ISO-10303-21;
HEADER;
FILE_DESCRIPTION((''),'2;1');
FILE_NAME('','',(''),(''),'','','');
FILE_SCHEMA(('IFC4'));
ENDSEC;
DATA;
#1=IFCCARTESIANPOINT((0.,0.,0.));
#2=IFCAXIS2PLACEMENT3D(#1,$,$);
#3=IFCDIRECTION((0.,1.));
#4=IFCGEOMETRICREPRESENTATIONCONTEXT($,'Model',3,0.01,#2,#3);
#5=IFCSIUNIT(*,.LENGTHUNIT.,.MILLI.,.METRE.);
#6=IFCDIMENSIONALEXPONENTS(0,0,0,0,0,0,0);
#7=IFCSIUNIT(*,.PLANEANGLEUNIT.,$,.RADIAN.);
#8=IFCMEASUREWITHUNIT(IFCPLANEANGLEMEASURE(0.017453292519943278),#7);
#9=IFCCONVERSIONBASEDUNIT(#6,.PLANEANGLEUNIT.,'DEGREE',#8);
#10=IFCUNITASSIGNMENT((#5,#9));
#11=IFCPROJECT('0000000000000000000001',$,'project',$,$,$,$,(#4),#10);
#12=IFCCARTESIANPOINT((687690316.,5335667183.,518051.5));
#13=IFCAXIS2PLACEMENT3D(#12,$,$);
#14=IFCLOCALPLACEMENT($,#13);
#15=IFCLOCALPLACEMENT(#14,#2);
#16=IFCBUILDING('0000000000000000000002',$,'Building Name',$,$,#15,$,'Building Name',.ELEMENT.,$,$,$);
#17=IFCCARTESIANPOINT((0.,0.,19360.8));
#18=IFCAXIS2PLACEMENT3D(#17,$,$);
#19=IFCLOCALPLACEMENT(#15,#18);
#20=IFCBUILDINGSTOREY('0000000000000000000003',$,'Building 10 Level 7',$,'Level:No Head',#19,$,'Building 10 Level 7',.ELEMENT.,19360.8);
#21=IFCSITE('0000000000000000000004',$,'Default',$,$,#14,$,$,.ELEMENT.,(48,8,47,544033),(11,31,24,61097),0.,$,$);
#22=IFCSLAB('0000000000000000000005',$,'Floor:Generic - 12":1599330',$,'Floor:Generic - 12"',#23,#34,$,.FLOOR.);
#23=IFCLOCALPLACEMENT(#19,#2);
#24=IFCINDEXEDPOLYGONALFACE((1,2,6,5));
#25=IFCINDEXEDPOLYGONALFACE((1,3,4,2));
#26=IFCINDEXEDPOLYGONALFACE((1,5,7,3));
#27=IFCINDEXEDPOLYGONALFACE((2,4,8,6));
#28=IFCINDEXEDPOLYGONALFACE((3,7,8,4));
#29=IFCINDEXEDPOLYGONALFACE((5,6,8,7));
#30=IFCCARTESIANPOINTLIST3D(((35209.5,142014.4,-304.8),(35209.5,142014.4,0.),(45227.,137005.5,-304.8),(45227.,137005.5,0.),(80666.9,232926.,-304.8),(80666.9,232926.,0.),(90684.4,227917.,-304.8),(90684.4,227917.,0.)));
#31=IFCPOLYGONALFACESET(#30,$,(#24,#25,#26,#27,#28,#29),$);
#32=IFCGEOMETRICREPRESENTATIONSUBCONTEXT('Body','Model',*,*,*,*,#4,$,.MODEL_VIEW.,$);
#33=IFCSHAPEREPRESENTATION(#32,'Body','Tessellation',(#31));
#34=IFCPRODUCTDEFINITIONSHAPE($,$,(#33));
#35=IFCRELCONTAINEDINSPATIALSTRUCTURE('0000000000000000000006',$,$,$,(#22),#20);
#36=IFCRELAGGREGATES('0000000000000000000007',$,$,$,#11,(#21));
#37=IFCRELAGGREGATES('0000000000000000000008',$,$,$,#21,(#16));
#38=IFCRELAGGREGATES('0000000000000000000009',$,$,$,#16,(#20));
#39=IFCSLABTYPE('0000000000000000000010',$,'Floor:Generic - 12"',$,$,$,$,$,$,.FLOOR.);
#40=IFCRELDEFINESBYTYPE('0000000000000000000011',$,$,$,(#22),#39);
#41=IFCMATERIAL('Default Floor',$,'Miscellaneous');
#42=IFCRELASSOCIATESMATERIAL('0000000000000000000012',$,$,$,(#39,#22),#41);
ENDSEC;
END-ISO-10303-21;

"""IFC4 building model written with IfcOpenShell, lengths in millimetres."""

from ifc_helpers import new_model, entity, si_unit, converted_unit, direction, frame, origin, place, context, subcontext, project, spatial, indexed_curve, outline, extrude, material, type_object, element, save


model = new_model("IFC4")

# Units and contexts
model_context = context("Model", 3, precision=0.01, world=origin(), true_north=direction((0.0, 1.0)))
body_context = subcontext(model_context, "Body", "Model", "MODEL_VIEW")
ifc_project = project(units=[si_unit("LENGTHUNIT", "METRE", prefix="MILLI"), converted_unit("PLANEANGLEUNIT", "DEGREE", entity("IfcPlaneAngleMeasure", 0.017453292519943278), si_unit("PLANEANGLEUNIT", "RADIAN"), dimensions=[0, 0, 0, 0, 0, 0, 0])], contexts=[model_context])

# Site, building, storey
site_placement = place(None, frame((687690316.0, 5335667183.0, 518051.5)))
site = spatial("IfcSite", under=ifc_project, at=site_placement, Name="Default", CompositionType="ELEMENT", RefLatitude=(48, 8, 47, 544033), RefLongitude=(11, 31, 24, 61097), RefElevation=0.0)
building_placement = place(site_placement, origin())
building = spatial("IfcBuilding", under=site, at=building_placement, Name="Building Name", LongName="Building Name", CompositionType="ELEMENT")
storey_placement = place(building_placement, frame((0.0, 0.0, 19360.8)))
storey = spatial("IfcBuildingStorey", under=building, at=storey_placement, Name="Building 10 Level 7", ObjectType="Level:No Head", LongName="Building 10 Level 7", CompositionType="ELEMENT", Elevation=19360.8)

# Slab
ifc_material = material(Name="Default Floor", Category="Miscellaneous")
slab_type = type_object("IfcSlabType", Name="Floor:Generic - 12\"", PredefinedType="FLOOR", material=ifc_material)
slab_placement = place(storey_placement, origin())
element("IfcSlab", 1, at=slab_placement, inside=storey, type_object=slab_type, material=ifc_material, Name="Floor:Generic - 12\":1599330", ObjectType="Floor:Generic - 12\"", PredefinedType="FLOOR", context=body_context, shape_type="SweptSolid", body=[
    extrude(outline(indexed_curve([(-50821.4, -5600.0), (50821.4, -5600.0), (50821.4, 5600.0), (-50821.4, 5600.0), (-50821.4, -5600.0)], self_intersect=False)), frame((62947.0, 184965.7, 0.0), z_axis=(0.0, 0.0, -1.0), x_axis=(-0.447226, -0.894421, 0.0)), (0.0, 0.0, 1.0), 304.8),
])

save(model, "model.ifc")
